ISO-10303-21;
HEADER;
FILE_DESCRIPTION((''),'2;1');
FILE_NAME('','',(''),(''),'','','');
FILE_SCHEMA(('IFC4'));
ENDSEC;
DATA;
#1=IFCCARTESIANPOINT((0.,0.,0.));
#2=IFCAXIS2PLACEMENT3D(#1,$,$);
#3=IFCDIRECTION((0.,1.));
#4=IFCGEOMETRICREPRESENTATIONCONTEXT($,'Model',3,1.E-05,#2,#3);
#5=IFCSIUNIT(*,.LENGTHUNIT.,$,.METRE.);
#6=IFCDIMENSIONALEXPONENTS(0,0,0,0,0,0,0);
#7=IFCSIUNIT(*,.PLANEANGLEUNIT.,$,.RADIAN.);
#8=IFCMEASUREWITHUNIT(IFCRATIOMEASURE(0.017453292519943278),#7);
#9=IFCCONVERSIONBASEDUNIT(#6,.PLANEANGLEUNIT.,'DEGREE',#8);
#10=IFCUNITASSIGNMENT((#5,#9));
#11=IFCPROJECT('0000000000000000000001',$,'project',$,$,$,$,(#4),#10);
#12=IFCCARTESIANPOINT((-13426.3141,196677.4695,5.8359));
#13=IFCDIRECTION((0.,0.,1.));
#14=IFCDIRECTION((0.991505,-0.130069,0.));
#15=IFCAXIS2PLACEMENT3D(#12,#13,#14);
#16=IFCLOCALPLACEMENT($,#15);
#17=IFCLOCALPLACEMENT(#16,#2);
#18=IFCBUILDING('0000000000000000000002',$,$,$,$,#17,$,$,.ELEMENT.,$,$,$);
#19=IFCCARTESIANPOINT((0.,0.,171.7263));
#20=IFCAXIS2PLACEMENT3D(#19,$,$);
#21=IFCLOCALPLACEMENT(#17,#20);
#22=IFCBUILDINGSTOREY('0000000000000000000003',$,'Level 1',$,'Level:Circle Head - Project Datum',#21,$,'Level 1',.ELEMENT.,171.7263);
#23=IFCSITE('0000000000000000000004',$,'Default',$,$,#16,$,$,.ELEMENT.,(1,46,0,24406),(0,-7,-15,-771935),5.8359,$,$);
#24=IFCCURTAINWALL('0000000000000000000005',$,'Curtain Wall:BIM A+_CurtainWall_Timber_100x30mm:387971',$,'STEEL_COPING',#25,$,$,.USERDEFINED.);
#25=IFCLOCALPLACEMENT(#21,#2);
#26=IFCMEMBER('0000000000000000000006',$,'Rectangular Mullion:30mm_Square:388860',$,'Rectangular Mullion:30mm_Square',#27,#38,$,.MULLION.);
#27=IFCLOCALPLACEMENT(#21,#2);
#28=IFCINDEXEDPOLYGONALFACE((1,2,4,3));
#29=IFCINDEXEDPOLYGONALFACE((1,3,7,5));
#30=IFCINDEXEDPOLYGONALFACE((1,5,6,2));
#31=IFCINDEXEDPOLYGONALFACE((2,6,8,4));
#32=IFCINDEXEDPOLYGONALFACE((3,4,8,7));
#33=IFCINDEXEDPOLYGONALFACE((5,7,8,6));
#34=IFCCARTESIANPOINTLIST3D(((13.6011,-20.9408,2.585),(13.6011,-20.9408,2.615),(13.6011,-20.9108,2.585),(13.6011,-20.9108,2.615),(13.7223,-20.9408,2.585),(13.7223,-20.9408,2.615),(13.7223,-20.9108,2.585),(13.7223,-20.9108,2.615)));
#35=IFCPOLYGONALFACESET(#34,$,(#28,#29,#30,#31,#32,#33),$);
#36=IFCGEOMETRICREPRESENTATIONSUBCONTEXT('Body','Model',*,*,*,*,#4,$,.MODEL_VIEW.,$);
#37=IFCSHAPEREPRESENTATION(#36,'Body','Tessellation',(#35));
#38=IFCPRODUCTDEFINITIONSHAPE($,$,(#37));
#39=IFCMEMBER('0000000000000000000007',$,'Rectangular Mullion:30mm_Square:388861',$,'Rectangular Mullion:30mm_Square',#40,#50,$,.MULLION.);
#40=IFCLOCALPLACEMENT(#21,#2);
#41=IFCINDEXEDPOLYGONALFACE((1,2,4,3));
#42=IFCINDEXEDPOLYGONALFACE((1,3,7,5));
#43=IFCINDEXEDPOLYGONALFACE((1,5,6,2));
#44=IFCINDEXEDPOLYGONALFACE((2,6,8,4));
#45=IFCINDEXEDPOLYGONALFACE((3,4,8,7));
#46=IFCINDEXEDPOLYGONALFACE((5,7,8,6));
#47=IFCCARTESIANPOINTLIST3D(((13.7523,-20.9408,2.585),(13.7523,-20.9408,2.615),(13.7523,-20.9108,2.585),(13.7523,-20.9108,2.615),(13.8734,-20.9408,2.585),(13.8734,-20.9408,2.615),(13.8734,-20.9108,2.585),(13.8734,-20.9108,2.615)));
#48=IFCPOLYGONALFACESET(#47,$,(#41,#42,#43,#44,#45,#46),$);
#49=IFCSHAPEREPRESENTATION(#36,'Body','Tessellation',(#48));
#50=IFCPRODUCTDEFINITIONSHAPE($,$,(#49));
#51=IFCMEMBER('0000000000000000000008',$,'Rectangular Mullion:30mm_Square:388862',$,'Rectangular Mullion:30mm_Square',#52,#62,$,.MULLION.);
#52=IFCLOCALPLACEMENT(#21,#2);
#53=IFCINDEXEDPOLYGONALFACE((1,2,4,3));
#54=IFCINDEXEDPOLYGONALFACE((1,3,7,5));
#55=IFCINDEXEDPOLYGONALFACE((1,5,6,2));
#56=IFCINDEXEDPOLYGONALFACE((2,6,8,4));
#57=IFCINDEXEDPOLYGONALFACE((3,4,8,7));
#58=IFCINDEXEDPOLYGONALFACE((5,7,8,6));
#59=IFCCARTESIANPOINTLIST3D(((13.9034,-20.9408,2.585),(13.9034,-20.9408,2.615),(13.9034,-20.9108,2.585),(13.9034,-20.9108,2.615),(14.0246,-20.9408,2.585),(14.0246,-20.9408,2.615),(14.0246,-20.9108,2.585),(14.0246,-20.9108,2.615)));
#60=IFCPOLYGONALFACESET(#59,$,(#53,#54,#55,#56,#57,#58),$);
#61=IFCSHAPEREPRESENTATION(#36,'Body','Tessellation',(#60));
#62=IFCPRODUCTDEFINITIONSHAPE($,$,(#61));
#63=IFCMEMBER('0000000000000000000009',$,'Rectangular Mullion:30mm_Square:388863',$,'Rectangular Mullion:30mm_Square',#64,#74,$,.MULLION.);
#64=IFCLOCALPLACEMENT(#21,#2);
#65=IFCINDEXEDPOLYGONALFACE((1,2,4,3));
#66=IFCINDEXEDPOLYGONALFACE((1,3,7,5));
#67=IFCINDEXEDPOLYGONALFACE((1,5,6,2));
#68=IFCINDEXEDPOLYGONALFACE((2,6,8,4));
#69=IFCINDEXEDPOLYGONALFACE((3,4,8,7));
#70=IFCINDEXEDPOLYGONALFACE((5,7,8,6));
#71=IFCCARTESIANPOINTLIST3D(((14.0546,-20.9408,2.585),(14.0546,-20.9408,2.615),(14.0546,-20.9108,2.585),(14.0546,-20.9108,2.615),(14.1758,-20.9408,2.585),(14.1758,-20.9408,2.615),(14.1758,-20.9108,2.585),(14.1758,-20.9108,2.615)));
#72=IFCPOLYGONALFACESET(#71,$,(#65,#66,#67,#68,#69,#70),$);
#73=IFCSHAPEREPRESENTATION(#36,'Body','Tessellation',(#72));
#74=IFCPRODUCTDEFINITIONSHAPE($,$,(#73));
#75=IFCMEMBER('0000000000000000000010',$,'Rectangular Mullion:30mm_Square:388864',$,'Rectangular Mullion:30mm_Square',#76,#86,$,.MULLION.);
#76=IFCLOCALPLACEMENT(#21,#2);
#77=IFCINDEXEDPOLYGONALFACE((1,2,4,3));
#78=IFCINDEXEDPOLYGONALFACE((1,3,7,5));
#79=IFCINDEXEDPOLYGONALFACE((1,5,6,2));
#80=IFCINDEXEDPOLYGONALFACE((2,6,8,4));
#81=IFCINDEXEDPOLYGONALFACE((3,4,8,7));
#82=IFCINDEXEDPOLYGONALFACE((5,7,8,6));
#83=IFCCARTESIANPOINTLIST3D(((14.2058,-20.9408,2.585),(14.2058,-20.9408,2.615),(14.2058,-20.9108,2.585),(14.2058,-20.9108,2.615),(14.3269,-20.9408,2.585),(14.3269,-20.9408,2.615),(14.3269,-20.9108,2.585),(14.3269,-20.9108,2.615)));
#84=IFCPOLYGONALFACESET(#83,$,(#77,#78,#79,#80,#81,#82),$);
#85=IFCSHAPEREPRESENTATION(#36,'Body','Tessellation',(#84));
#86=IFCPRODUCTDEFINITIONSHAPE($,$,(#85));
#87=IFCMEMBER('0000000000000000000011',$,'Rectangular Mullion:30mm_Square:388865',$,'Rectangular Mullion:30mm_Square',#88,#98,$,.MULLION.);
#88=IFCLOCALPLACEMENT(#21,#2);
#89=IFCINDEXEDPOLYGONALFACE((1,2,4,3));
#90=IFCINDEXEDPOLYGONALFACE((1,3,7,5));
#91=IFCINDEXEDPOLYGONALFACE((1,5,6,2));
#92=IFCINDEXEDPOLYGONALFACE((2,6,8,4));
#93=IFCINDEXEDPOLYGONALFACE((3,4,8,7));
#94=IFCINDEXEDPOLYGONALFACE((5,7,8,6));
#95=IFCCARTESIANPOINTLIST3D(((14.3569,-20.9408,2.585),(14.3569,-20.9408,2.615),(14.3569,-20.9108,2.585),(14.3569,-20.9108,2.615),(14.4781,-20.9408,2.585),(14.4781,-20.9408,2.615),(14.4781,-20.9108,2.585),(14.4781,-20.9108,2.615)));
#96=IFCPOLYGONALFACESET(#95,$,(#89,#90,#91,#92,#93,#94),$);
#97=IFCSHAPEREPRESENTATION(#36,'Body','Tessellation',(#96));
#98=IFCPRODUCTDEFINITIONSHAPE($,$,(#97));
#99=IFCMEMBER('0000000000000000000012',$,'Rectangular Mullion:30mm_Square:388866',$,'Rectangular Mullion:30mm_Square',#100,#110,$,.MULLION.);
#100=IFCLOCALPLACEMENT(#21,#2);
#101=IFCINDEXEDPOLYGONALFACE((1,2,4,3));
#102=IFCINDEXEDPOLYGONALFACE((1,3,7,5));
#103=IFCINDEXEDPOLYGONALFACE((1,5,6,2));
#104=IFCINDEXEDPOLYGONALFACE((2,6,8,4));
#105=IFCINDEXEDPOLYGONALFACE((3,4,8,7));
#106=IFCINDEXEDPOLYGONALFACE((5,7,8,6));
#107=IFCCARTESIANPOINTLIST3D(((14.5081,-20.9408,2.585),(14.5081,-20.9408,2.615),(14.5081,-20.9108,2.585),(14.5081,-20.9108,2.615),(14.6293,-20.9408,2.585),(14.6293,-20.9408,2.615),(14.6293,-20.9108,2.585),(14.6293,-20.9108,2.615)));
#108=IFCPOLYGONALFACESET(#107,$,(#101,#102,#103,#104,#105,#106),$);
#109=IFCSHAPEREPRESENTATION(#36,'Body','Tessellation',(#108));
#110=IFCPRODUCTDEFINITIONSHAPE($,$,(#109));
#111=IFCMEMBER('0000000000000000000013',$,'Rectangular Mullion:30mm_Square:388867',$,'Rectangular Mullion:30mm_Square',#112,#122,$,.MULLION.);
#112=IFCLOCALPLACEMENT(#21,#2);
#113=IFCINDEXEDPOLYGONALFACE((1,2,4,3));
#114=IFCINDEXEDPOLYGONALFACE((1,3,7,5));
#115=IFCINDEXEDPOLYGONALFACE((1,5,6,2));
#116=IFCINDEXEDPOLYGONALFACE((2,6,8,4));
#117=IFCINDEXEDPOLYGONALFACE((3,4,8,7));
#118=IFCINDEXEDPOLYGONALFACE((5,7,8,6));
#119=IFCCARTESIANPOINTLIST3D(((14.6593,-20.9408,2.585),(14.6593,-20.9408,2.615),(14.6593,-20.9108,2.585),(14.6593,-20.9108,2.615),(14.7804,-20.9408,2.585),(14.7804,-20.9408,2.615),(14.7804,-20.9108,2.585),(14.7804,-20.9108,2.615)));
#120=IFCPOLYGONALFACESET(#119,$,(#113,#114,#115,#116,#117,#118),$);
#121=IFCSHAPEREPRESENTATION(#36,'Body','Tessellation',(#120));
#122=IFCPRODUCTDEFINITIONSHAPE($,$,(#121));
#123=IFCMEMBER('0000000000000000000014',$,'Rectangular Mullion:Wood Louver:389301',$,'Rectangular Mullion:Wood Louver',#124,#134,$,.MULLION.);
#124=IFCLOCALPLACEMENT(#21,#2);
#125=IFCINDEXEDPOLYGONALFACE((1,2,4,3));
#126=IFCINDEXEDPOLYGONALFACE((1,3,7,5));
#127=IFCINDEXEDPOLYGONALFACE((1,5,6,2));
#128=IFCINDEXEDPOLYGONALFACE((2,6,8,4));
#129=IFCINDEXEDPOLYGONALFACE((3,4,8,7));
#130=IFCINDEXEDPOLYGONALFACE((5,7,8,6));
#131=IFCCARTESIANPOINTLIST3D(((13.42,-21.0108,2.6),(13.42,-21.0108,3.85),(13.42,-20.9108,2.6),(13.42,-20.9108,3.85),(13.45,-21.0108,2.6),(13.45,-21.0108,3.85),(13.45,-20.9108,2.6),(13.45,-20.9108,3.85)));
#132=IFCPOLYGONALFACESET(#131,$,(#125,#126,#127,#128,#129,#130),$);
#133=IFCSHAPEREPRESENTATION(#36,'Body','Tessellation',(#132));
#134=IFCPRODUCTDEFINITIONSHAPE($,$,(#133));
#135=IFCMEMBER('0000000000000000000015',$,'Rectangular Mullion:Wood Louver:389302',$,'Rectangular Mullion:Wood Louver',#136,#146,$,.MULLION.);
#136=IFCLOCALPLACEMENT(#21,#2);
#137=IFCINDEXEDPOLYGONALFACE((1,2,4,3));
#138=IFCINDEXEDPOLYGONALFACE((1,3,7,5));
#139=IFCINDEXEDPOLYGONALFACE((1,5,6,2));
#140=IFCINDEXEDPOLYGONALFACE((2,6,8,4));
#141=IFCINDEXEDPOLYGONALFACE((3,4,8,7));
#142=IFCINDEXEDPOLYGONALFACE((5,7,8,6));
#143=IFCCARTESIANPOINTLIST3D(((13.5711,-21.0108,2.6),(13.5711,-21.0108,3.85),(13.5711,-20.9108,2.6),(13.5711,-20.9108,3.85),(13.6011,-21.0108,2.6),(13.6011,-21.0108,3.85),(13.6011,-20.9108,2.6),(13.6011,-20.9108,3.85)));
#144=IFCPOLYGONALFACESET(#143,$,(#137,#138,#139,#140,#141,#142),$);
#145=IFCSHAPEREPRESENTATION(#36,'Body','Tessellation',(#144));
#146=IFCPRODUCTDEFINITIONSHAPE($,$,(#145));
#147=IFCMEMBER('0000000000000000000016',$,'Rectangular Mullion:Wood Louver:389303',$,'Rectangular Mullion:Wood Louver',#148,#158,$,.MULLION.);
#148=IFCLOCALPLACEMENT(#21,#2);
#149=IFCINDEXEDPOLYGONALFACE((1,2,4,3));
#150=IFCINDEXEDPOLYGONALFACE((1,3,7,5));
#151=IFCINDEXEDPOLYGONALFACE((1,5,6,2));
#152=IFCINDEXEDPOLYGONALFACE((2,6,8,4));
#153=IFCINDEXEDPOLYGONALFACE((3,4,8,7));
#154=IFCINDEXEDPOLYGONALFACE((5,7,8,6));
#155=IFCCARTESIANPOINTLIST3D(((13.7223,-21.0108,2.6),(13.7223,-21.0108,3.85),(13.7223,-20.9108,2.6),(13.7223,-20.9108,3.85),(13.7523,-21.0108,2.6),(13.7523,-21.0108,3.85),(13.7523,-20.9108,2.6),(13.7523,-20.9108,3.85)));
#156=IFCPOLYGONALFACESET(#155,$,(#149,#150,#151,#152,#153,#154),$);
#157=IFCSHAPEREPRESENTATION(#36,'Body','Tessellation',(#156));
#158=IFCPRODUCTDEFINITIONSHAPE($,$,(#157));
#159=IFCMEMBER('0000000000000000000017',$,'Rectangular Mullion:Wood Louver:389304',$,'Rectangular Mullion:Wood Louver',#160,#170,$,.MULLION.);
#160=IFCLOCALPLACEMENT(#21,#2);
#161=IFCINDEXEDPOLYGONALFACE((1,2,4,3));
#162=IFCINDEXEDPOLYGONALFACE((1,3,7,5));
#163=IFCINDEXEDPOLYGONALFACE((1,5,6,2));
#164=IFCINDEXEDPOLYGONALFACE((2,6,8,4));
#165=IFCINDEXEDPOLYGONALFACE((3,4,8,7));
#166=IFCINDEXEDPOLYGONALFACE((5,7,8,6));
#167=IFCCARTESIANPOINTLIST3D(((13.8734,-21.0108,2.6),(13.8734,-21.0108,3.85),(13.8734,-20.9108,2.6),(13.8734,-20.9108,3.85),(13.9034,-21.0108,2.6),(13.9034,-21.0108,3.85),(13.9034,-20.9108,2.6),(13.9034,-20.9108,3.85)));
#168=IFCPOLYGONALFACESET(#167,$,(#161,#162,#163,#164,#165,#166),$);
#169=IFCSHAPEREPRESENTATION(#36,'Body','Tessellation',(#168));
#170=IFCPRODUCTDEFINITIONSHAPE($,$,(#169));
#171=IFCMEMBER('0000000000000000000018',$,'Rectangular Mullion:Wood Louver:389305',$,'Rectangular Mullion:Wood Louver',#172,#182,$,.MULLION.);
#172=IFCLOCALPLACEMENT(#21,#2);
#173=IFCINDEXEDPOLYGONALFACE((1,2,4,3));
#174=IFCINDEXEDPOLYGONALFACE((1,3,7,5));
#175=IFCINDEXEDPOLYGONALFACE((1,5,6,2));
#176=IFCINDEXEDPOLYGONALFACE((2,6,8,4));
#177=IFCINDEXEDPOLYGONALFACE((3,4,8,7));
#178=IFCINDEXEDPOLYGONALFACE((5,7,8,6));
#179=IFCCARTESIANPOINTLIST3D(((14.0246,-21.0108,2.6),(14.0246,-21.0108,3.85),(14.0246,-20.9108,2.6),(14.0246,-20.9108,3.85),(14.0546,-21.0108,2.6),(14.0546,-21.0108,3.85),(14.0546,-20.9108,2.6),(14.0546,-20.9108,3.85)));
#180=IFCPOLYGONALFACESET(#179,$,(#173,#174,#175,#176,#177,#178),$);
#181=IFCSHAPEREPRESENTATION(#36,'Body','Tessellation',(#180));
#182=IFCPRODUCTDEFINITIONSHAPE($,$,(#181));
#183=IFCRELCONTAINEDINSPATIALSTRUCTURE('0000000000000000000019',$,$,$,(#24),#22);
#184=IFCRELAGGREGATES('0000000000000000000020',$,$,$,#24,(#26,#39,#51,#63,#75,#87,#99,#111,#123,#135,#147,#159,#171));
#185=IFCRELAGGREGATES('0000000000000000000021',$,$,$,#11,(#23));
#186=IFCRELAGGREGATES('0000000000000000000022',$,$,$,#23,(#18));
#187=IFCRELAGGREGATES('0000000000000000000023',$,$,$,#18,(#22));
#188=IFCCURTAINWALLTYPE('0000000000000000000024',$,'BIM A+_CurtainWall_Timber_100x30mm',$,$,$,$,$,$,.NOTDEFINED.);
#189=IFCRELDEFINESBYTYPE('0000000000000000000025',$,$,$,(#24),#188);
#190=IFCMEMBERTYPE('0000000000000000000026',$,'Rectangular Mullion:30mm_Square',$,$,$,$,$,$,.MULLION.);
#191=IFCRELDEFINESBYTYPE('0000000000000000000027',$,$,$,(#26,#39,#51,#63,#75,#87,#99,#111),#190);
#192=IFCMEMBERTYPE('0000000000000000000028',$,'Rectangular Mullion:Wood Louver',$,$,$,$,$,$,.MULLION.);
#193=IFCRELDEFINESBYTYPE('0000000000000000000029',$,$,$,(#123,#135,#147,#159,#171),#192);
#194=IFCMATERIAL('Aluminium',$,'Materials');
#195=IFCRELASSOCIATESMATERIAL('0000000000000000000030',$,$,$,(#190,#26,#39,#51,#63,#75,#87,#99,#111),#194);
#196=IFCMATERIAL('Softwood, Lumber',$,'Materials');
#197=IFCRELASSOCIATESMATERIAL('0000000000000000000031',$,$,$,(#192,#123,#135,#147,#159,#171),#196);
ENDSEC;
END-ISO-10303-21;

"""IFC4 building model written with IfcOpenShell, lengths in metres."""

from ifc_helpers import new_model, entity, si_unit, converted_unit, direction, frame, origin, place, context, subcontext, project, spatial, indexed_curve, outline, extrude, source, transform, mapped, material, type_object, type_shapes, element, aggregate, save


model = new_model("IFC4")

# Units and contexts
model_context = context("Model", 3, precision=1e-05, world=origin(), true_north=direction((0.0, 1.0)))
body_context = subcontext(model_context, "Body", "Model", "MODEL_VIEW")
ifc_project = project(units=[si_unit("LENGTHUNIT", "METRE"), converted_unit("PLANEANGLEUNIT", "DEGREE", entity("IfcRatioMeasure", 0.017453292519943278), si_unit("PLANEANGLEUNIT", "RADIAN"), dimensions=[0, 0, 0, 0, 0, 0, 0])], contexts=[model_context])

# Site, building, storey
site_placement = place(None, frame((-13426.3141, 196677.4695, 5.8359), z_axis=(0.0, 0.0, 1.0), x_axis=(0.991505, -0.130069, 0.0)))
site = spatial("IfcSite", under=ifc_project, at=site_placement, Name="Default", CompositionType="ELEMENT", RefLatitude=(1, 46, 0, 24406), RefLongitude=(0, -7, -15, -771935), RefElevation=5.8359)
building_placement = place(site_placement, origin())
building = spatial("IfcBuilding", under=site, at=building_placement, CompositionType="ELEMENT")
storey_placement = place(building_placement, frame((0.0, 0.0, 171.7263)))
storey = spatial("IfcBuildingStorey", under=building, at=storey_placement, Name="Level 1", ObjectType="Level:Circle Head - Project Datum", LongName="Level 1", CompositionType="ELEMENT", Elevation=171.7263)

# Curtain wall, members
curtain_wall_type = type_object("IfcCurtainWallType", Name="BIM A+_CurtainWall_Timber_100x30mm", PredefinedType="NOTDEFINED")
curtain_wall_placement = place(storey_placement, frame((0.0, 0.0, -171.7263)))
curtain_wall = element("IfcCurtainWall", 1, at=curtain_wall_placement, inside=storey, type_object=curtain_wall_type, Name="Curtain Wall:BIM A+_CurtainWall_Timber_100x30mm:387971", ObjectType="STEEL_COPING", PredefinedType="USERDEFINED")
ifc_material_1 = material(Name="Aluminium", Category="Materials")
member_type_1 = type_object("IfcMemberType", Name="Rectangular Mullion:30mm_Square", PredefinedType="MULLION", material=ifc_material_1)
shared_shape_1 = source(origin(), body_context, "Body", "SweptSolid", [
    extrude(outline(indexed_curve([(-0.015, -0.015), (0.015, -0.015), (0.015, 0.015), (-0.015, 0.015), (-0.015, -0.015)], self_intersect=False)), frame((0.0, 0.0, -0.1212), z_axis=(0.0, 0.0, 1.0), x_axis=(0.0, -1.0, 0.0)), (0.0, 0.0, 1.0), 0.1212),
])
type_shapes(member_type_1, [shared_shape_1])
member_1_placement = place(curtain_wall_placement, frame((13.7223, -20.9258, 174.3263), z_axis=(1.0, 0.0, 0.0), x_axis=(0.0, 0.0, 1.0)))
member_1 = element("IfcMember", 2, at=member_1_placement, type_object=member_type_1, material=ifc_material_1, Name="Rectangular Mullion:30mm_Square:388860", ObjectType="Rectangular Mullion:30mm_Square", PredefinedType="MULLION", context=body_context, shape_type="MappedRepresentation", body=[
    mapped(shared_shape_1, transform((0.0, 0.0, 0.0), scale=1.0)),
])
member_2_placement = place(curtain_wall_placement, frame((13.8734, -20.9258, 174.3263), z_axis=(1.0, 0.0, 0.0), x_axis=(0.0, 0.0, 1.0)))
member_2 = element("IfcMember", 3, at=member_2_placement, type_object=member_type_1, material=ifc_material_1, Name="Rectangular Mullion:30mm_Square:388861", ObjectType="Rectangular Mullion:30mm_Square", PredefinedType="MULLION", context=body_context, shape_type="MappedRepresentation", body=[
    mapped(shared_shape_1, transform((0.0, 0.0, 0.0), scale=1.0)),
])
member_3_placement = place(curtain_wall_placement, frame((14.0246, -20.9258, 174.3263), z_axis=(1.0, 0.0, 0.0), x_axis=(0.0, 0.0, 1.0)))
member_3 = element("IfcMember", 4, at=member_3_placement, type_object=member_type_1, material=ifc_material_1, Name="Rectangular Mullion:30mm_Square:388862", ObjectType="Rectangular Mullion:30mm_Square", PredefinedType="MULLION", context=body_context, shape_type="MappedRepresentation", body=[
    mapped(shared_shape_1, transform((0.0, 0.0, 0.0), scale=1.0)),
])
member_4_placement = place(curtain_wall_placement, frame((14.1758, -20.9258, 174.3263), z_axis=(1.0, 0.0, 0.0), x_axis=(0.0, 0.0, 1.0)))
member_4 = element("IfcMember", 5, at=member_4_placement, type_object=member_type_1, material=ifc_material_1, Name="Rectangular Mullion:30mm_Square:388863", ObjectType="Rectangular Mullion:30mm_Square", PredefinedType="MULLION", context=body_context, shape_type="MappedRepresentation", body=[
    mapped(shared_shape_1, transform((0.0, 0.0, 0.0), scale=1.0)),
])
member_5_placement = place(curtain_wall_placement, frame((14.3269, -20.9258, 174.3263), z_axis=(1.0, 0.0, 0.0), x_axis=(0.0, 0.0, 1.0)))
member_5 = element("IfcMember", 6, at=member_5_placement, type_object=member_type_1, material=ifc_material_1, Name="Rectangular Mullion:30mm_Square:388864", ObjectType="Rectangular Mullion:30mm_Square", PredefinedType="MULLION", context=body_context, shape_type="MappedRepresentation", body=[
    mapped(shared_shape_1, transform((0.0, 0.0, 0.0), scale=1.0)),
])
member_6_placement = place(curtain_wall_placement, frame((14.4781, -20.9258, 174.3263), z_axis=(1.0, 0.0, 0.0), x_axis=(0.0, 0.0, 1.0)))
member_6 = element("IfcMember", 7, at=member_6_placement, type_object=member_type_1, material=ifc_material_1, Name="Rectangular Mullion:30mm_Square:388865", ObjectType="Rectangular Mullion:30mm_Square", PredefinedType="MULLION", context=body_context, shape_type="MappedRepresentation", body=[
    mapped(shared_shape_1, transform((0.0, 0.0, 0.0), scale=1.0)),
])
member_7_placement = place(curtain_wall_placement, frame((14.6293, -20.9258, 174.3263), z_axis=(1.0, 0.0, 0.0), x_axis=(0.0, 0.0, 1.0)))
member_7 = element("IfcMember", 8, at=member_7_placement, type_object=member_type_1, material=ifc_material_1, Name="Rectangular Mullion:30mm_Square:388866", ObjectType="Rectangular Mullion:30mm_Square", PredefinedType="MULLION", context=body_context, shape_type="MappedRepresentation", body=[
    mapped(shared_shape_1, transform((0.0, 0.0, 0.0), scale=1.0)),
])
member_8_placement = place(curtain_wall_placement, frame((14.7804, -20.9258, 174.3263), z_axis=(1.0, 0.0, 0.0), x_axis=(0.0, 0.0, 1.0)))
member_8 = element("IfcMember", 9, at=member_8_placement, type_object=member_type_1, material=ifc_material_1, Name="Rectangular Mullion:30mm_Square:388867", ObjectType="Rectangular Mullion:30mm_Square", PredefinedType="MULLION", context=body_context, shape_type="MappedRepresentation", body=[
    mapped(shared_shape_1, transform((0.0, 0.0, 0.0), scale=1.0)),
])
ifc_material_2 = material(Name="Softwood, Lumber", Category="Materials")
member_type_2 = type_object("IfcMemberType", Name="Rectangular Mullion:Wood Louver", PredefinedType="MULLION", material=ifc_material_2)
shared_shape_2 = source(origin(), body_context, "Body", "SweptSolid", [
    extrude(outline(indexed_curve([(-0.05, -0.015), (0.05, -0.015), (0.05, 0.015), (-0.05, 0.015), (-0.05, -0.015)], self_intersect=False)), frame((0.0, 0.035, -1.25), z_axis=(0.0, 0.0, 1.0), x_axis=(0.0, -1.0, 0.0)), (0.0, 0.0, 1.0), 1.25),
])
type_shapes(member_type_2, [shared_shape_2])
member_9_placement = place(curtain_wall_placement, frame((13.435, -20.9258, 174.3263), z_axis=(0.0, 0.0, -1.0), x_axis=(1.0, 0.0, 0.0)))
member_9 = element("IfcMember", 10, at=member_9_placement, type_object=member_type_2, material=ifc_material_2, Name="Rectangular Mullion:Wood Louver:389301", ObjectType="Rectangular Mullion:Wood Louver", PredefinedType="MULLION", context=body_context, shape_type="MappedRepresentation", body=[
    mapped(shared_shape_2, transform((0.0, 0.0, 0.0), scale=1.0)),
])
member_10_placement = place(curtain_wall_placement, frame((13.5861, -20.9258, 174.3263), z_axis=(0.0, 0.0, -1.0), x_axis=(1.0, 0.0, 0.0)))
member_10 = element("IfcMember", 11, at=member_10_placement, type_object=member_type_2, material=ifc_material_2, Name="Rectangular Mullion:Wood Louver:389302", ObjectType="Rectangular Mullion:Wood Louver", PredefinedType="MULLION", context=body_context, shape_type="MappedRepresentation", body=[
    mapped(shared_shape_2, transform((0.0, 0.0, 0.0), scale=1.0)),
])
member_11_placement = place(curtain_wall_placement, frame((13.7373, -20.9258, 174.3263), z_axis=(0.0, 0.0, -1.0), x_axis=(1.0, 0.0, 0.0)))
member_11 = element("IfcMember", 12, at=member_11_placement, type_object=member_type_2, material=ifc_material_2, Name="Rectangular Mullion:Wood Louver:389303", ObjectType="Rectangular Mullion:Wood Louver", PredefinedType="MULLION", context=body_context, shape_type="MappedRepresentation", body=[
    mapped(shared_shape_2, transform((0.0, 0.0, 0.0), scale=1.0)),
])
member_12_placement = place(curtain_wall_placement, frame((13.8884, -20.9258, 174.3263), z_axis=(0.0, 0.0, -1.0), x_axis=(1.0, 0.0, 0.0)))
member_12 = element("IfcMember", 13, at=member_12_placement, type_object=member_type_2, material=ifc_material_2, Name="Rectangular Mullion:Wood Louver:389304", ObjectType="Rectangular Mullion:Wood Louver", PredefinedType="MULLION", context=body_context, shape_type="MappedRepresentation", body=[
    mapped(shared_shape_2, transform((0.0, 0.0, 0.0), scale=1.0)),
])
member_13_placement = place(curtain_wall_placement, frame((14.0396, -20.9258, 174.3263), z_axis=(0.0, 0.0, -1.0), x_axis=(1.0, 0.0, 0.0)))
member_13 = element("IfcMember", 14, at=member_13_placement, type_object=member_type_2, material=ifc_material_2, Name="Rectangular Mullion:Wood Louver:389305", ObjectType="Rectangular Mullion:Wood Louver", PredefinedType="MULLION", context=body_context, shape_type="MappedRepresentation", body=[
    mapped(shared_shape_2, transform((0.0, 0.0, 0.0), scale=1.0)),
])
aggregate(curtain_wall, [member_1, member_2, member_3, member_4, member_5, member_6, member_7, member_8, member_9, member_10, member_11, member_12, member_13])

save(model, "model.ifc")
